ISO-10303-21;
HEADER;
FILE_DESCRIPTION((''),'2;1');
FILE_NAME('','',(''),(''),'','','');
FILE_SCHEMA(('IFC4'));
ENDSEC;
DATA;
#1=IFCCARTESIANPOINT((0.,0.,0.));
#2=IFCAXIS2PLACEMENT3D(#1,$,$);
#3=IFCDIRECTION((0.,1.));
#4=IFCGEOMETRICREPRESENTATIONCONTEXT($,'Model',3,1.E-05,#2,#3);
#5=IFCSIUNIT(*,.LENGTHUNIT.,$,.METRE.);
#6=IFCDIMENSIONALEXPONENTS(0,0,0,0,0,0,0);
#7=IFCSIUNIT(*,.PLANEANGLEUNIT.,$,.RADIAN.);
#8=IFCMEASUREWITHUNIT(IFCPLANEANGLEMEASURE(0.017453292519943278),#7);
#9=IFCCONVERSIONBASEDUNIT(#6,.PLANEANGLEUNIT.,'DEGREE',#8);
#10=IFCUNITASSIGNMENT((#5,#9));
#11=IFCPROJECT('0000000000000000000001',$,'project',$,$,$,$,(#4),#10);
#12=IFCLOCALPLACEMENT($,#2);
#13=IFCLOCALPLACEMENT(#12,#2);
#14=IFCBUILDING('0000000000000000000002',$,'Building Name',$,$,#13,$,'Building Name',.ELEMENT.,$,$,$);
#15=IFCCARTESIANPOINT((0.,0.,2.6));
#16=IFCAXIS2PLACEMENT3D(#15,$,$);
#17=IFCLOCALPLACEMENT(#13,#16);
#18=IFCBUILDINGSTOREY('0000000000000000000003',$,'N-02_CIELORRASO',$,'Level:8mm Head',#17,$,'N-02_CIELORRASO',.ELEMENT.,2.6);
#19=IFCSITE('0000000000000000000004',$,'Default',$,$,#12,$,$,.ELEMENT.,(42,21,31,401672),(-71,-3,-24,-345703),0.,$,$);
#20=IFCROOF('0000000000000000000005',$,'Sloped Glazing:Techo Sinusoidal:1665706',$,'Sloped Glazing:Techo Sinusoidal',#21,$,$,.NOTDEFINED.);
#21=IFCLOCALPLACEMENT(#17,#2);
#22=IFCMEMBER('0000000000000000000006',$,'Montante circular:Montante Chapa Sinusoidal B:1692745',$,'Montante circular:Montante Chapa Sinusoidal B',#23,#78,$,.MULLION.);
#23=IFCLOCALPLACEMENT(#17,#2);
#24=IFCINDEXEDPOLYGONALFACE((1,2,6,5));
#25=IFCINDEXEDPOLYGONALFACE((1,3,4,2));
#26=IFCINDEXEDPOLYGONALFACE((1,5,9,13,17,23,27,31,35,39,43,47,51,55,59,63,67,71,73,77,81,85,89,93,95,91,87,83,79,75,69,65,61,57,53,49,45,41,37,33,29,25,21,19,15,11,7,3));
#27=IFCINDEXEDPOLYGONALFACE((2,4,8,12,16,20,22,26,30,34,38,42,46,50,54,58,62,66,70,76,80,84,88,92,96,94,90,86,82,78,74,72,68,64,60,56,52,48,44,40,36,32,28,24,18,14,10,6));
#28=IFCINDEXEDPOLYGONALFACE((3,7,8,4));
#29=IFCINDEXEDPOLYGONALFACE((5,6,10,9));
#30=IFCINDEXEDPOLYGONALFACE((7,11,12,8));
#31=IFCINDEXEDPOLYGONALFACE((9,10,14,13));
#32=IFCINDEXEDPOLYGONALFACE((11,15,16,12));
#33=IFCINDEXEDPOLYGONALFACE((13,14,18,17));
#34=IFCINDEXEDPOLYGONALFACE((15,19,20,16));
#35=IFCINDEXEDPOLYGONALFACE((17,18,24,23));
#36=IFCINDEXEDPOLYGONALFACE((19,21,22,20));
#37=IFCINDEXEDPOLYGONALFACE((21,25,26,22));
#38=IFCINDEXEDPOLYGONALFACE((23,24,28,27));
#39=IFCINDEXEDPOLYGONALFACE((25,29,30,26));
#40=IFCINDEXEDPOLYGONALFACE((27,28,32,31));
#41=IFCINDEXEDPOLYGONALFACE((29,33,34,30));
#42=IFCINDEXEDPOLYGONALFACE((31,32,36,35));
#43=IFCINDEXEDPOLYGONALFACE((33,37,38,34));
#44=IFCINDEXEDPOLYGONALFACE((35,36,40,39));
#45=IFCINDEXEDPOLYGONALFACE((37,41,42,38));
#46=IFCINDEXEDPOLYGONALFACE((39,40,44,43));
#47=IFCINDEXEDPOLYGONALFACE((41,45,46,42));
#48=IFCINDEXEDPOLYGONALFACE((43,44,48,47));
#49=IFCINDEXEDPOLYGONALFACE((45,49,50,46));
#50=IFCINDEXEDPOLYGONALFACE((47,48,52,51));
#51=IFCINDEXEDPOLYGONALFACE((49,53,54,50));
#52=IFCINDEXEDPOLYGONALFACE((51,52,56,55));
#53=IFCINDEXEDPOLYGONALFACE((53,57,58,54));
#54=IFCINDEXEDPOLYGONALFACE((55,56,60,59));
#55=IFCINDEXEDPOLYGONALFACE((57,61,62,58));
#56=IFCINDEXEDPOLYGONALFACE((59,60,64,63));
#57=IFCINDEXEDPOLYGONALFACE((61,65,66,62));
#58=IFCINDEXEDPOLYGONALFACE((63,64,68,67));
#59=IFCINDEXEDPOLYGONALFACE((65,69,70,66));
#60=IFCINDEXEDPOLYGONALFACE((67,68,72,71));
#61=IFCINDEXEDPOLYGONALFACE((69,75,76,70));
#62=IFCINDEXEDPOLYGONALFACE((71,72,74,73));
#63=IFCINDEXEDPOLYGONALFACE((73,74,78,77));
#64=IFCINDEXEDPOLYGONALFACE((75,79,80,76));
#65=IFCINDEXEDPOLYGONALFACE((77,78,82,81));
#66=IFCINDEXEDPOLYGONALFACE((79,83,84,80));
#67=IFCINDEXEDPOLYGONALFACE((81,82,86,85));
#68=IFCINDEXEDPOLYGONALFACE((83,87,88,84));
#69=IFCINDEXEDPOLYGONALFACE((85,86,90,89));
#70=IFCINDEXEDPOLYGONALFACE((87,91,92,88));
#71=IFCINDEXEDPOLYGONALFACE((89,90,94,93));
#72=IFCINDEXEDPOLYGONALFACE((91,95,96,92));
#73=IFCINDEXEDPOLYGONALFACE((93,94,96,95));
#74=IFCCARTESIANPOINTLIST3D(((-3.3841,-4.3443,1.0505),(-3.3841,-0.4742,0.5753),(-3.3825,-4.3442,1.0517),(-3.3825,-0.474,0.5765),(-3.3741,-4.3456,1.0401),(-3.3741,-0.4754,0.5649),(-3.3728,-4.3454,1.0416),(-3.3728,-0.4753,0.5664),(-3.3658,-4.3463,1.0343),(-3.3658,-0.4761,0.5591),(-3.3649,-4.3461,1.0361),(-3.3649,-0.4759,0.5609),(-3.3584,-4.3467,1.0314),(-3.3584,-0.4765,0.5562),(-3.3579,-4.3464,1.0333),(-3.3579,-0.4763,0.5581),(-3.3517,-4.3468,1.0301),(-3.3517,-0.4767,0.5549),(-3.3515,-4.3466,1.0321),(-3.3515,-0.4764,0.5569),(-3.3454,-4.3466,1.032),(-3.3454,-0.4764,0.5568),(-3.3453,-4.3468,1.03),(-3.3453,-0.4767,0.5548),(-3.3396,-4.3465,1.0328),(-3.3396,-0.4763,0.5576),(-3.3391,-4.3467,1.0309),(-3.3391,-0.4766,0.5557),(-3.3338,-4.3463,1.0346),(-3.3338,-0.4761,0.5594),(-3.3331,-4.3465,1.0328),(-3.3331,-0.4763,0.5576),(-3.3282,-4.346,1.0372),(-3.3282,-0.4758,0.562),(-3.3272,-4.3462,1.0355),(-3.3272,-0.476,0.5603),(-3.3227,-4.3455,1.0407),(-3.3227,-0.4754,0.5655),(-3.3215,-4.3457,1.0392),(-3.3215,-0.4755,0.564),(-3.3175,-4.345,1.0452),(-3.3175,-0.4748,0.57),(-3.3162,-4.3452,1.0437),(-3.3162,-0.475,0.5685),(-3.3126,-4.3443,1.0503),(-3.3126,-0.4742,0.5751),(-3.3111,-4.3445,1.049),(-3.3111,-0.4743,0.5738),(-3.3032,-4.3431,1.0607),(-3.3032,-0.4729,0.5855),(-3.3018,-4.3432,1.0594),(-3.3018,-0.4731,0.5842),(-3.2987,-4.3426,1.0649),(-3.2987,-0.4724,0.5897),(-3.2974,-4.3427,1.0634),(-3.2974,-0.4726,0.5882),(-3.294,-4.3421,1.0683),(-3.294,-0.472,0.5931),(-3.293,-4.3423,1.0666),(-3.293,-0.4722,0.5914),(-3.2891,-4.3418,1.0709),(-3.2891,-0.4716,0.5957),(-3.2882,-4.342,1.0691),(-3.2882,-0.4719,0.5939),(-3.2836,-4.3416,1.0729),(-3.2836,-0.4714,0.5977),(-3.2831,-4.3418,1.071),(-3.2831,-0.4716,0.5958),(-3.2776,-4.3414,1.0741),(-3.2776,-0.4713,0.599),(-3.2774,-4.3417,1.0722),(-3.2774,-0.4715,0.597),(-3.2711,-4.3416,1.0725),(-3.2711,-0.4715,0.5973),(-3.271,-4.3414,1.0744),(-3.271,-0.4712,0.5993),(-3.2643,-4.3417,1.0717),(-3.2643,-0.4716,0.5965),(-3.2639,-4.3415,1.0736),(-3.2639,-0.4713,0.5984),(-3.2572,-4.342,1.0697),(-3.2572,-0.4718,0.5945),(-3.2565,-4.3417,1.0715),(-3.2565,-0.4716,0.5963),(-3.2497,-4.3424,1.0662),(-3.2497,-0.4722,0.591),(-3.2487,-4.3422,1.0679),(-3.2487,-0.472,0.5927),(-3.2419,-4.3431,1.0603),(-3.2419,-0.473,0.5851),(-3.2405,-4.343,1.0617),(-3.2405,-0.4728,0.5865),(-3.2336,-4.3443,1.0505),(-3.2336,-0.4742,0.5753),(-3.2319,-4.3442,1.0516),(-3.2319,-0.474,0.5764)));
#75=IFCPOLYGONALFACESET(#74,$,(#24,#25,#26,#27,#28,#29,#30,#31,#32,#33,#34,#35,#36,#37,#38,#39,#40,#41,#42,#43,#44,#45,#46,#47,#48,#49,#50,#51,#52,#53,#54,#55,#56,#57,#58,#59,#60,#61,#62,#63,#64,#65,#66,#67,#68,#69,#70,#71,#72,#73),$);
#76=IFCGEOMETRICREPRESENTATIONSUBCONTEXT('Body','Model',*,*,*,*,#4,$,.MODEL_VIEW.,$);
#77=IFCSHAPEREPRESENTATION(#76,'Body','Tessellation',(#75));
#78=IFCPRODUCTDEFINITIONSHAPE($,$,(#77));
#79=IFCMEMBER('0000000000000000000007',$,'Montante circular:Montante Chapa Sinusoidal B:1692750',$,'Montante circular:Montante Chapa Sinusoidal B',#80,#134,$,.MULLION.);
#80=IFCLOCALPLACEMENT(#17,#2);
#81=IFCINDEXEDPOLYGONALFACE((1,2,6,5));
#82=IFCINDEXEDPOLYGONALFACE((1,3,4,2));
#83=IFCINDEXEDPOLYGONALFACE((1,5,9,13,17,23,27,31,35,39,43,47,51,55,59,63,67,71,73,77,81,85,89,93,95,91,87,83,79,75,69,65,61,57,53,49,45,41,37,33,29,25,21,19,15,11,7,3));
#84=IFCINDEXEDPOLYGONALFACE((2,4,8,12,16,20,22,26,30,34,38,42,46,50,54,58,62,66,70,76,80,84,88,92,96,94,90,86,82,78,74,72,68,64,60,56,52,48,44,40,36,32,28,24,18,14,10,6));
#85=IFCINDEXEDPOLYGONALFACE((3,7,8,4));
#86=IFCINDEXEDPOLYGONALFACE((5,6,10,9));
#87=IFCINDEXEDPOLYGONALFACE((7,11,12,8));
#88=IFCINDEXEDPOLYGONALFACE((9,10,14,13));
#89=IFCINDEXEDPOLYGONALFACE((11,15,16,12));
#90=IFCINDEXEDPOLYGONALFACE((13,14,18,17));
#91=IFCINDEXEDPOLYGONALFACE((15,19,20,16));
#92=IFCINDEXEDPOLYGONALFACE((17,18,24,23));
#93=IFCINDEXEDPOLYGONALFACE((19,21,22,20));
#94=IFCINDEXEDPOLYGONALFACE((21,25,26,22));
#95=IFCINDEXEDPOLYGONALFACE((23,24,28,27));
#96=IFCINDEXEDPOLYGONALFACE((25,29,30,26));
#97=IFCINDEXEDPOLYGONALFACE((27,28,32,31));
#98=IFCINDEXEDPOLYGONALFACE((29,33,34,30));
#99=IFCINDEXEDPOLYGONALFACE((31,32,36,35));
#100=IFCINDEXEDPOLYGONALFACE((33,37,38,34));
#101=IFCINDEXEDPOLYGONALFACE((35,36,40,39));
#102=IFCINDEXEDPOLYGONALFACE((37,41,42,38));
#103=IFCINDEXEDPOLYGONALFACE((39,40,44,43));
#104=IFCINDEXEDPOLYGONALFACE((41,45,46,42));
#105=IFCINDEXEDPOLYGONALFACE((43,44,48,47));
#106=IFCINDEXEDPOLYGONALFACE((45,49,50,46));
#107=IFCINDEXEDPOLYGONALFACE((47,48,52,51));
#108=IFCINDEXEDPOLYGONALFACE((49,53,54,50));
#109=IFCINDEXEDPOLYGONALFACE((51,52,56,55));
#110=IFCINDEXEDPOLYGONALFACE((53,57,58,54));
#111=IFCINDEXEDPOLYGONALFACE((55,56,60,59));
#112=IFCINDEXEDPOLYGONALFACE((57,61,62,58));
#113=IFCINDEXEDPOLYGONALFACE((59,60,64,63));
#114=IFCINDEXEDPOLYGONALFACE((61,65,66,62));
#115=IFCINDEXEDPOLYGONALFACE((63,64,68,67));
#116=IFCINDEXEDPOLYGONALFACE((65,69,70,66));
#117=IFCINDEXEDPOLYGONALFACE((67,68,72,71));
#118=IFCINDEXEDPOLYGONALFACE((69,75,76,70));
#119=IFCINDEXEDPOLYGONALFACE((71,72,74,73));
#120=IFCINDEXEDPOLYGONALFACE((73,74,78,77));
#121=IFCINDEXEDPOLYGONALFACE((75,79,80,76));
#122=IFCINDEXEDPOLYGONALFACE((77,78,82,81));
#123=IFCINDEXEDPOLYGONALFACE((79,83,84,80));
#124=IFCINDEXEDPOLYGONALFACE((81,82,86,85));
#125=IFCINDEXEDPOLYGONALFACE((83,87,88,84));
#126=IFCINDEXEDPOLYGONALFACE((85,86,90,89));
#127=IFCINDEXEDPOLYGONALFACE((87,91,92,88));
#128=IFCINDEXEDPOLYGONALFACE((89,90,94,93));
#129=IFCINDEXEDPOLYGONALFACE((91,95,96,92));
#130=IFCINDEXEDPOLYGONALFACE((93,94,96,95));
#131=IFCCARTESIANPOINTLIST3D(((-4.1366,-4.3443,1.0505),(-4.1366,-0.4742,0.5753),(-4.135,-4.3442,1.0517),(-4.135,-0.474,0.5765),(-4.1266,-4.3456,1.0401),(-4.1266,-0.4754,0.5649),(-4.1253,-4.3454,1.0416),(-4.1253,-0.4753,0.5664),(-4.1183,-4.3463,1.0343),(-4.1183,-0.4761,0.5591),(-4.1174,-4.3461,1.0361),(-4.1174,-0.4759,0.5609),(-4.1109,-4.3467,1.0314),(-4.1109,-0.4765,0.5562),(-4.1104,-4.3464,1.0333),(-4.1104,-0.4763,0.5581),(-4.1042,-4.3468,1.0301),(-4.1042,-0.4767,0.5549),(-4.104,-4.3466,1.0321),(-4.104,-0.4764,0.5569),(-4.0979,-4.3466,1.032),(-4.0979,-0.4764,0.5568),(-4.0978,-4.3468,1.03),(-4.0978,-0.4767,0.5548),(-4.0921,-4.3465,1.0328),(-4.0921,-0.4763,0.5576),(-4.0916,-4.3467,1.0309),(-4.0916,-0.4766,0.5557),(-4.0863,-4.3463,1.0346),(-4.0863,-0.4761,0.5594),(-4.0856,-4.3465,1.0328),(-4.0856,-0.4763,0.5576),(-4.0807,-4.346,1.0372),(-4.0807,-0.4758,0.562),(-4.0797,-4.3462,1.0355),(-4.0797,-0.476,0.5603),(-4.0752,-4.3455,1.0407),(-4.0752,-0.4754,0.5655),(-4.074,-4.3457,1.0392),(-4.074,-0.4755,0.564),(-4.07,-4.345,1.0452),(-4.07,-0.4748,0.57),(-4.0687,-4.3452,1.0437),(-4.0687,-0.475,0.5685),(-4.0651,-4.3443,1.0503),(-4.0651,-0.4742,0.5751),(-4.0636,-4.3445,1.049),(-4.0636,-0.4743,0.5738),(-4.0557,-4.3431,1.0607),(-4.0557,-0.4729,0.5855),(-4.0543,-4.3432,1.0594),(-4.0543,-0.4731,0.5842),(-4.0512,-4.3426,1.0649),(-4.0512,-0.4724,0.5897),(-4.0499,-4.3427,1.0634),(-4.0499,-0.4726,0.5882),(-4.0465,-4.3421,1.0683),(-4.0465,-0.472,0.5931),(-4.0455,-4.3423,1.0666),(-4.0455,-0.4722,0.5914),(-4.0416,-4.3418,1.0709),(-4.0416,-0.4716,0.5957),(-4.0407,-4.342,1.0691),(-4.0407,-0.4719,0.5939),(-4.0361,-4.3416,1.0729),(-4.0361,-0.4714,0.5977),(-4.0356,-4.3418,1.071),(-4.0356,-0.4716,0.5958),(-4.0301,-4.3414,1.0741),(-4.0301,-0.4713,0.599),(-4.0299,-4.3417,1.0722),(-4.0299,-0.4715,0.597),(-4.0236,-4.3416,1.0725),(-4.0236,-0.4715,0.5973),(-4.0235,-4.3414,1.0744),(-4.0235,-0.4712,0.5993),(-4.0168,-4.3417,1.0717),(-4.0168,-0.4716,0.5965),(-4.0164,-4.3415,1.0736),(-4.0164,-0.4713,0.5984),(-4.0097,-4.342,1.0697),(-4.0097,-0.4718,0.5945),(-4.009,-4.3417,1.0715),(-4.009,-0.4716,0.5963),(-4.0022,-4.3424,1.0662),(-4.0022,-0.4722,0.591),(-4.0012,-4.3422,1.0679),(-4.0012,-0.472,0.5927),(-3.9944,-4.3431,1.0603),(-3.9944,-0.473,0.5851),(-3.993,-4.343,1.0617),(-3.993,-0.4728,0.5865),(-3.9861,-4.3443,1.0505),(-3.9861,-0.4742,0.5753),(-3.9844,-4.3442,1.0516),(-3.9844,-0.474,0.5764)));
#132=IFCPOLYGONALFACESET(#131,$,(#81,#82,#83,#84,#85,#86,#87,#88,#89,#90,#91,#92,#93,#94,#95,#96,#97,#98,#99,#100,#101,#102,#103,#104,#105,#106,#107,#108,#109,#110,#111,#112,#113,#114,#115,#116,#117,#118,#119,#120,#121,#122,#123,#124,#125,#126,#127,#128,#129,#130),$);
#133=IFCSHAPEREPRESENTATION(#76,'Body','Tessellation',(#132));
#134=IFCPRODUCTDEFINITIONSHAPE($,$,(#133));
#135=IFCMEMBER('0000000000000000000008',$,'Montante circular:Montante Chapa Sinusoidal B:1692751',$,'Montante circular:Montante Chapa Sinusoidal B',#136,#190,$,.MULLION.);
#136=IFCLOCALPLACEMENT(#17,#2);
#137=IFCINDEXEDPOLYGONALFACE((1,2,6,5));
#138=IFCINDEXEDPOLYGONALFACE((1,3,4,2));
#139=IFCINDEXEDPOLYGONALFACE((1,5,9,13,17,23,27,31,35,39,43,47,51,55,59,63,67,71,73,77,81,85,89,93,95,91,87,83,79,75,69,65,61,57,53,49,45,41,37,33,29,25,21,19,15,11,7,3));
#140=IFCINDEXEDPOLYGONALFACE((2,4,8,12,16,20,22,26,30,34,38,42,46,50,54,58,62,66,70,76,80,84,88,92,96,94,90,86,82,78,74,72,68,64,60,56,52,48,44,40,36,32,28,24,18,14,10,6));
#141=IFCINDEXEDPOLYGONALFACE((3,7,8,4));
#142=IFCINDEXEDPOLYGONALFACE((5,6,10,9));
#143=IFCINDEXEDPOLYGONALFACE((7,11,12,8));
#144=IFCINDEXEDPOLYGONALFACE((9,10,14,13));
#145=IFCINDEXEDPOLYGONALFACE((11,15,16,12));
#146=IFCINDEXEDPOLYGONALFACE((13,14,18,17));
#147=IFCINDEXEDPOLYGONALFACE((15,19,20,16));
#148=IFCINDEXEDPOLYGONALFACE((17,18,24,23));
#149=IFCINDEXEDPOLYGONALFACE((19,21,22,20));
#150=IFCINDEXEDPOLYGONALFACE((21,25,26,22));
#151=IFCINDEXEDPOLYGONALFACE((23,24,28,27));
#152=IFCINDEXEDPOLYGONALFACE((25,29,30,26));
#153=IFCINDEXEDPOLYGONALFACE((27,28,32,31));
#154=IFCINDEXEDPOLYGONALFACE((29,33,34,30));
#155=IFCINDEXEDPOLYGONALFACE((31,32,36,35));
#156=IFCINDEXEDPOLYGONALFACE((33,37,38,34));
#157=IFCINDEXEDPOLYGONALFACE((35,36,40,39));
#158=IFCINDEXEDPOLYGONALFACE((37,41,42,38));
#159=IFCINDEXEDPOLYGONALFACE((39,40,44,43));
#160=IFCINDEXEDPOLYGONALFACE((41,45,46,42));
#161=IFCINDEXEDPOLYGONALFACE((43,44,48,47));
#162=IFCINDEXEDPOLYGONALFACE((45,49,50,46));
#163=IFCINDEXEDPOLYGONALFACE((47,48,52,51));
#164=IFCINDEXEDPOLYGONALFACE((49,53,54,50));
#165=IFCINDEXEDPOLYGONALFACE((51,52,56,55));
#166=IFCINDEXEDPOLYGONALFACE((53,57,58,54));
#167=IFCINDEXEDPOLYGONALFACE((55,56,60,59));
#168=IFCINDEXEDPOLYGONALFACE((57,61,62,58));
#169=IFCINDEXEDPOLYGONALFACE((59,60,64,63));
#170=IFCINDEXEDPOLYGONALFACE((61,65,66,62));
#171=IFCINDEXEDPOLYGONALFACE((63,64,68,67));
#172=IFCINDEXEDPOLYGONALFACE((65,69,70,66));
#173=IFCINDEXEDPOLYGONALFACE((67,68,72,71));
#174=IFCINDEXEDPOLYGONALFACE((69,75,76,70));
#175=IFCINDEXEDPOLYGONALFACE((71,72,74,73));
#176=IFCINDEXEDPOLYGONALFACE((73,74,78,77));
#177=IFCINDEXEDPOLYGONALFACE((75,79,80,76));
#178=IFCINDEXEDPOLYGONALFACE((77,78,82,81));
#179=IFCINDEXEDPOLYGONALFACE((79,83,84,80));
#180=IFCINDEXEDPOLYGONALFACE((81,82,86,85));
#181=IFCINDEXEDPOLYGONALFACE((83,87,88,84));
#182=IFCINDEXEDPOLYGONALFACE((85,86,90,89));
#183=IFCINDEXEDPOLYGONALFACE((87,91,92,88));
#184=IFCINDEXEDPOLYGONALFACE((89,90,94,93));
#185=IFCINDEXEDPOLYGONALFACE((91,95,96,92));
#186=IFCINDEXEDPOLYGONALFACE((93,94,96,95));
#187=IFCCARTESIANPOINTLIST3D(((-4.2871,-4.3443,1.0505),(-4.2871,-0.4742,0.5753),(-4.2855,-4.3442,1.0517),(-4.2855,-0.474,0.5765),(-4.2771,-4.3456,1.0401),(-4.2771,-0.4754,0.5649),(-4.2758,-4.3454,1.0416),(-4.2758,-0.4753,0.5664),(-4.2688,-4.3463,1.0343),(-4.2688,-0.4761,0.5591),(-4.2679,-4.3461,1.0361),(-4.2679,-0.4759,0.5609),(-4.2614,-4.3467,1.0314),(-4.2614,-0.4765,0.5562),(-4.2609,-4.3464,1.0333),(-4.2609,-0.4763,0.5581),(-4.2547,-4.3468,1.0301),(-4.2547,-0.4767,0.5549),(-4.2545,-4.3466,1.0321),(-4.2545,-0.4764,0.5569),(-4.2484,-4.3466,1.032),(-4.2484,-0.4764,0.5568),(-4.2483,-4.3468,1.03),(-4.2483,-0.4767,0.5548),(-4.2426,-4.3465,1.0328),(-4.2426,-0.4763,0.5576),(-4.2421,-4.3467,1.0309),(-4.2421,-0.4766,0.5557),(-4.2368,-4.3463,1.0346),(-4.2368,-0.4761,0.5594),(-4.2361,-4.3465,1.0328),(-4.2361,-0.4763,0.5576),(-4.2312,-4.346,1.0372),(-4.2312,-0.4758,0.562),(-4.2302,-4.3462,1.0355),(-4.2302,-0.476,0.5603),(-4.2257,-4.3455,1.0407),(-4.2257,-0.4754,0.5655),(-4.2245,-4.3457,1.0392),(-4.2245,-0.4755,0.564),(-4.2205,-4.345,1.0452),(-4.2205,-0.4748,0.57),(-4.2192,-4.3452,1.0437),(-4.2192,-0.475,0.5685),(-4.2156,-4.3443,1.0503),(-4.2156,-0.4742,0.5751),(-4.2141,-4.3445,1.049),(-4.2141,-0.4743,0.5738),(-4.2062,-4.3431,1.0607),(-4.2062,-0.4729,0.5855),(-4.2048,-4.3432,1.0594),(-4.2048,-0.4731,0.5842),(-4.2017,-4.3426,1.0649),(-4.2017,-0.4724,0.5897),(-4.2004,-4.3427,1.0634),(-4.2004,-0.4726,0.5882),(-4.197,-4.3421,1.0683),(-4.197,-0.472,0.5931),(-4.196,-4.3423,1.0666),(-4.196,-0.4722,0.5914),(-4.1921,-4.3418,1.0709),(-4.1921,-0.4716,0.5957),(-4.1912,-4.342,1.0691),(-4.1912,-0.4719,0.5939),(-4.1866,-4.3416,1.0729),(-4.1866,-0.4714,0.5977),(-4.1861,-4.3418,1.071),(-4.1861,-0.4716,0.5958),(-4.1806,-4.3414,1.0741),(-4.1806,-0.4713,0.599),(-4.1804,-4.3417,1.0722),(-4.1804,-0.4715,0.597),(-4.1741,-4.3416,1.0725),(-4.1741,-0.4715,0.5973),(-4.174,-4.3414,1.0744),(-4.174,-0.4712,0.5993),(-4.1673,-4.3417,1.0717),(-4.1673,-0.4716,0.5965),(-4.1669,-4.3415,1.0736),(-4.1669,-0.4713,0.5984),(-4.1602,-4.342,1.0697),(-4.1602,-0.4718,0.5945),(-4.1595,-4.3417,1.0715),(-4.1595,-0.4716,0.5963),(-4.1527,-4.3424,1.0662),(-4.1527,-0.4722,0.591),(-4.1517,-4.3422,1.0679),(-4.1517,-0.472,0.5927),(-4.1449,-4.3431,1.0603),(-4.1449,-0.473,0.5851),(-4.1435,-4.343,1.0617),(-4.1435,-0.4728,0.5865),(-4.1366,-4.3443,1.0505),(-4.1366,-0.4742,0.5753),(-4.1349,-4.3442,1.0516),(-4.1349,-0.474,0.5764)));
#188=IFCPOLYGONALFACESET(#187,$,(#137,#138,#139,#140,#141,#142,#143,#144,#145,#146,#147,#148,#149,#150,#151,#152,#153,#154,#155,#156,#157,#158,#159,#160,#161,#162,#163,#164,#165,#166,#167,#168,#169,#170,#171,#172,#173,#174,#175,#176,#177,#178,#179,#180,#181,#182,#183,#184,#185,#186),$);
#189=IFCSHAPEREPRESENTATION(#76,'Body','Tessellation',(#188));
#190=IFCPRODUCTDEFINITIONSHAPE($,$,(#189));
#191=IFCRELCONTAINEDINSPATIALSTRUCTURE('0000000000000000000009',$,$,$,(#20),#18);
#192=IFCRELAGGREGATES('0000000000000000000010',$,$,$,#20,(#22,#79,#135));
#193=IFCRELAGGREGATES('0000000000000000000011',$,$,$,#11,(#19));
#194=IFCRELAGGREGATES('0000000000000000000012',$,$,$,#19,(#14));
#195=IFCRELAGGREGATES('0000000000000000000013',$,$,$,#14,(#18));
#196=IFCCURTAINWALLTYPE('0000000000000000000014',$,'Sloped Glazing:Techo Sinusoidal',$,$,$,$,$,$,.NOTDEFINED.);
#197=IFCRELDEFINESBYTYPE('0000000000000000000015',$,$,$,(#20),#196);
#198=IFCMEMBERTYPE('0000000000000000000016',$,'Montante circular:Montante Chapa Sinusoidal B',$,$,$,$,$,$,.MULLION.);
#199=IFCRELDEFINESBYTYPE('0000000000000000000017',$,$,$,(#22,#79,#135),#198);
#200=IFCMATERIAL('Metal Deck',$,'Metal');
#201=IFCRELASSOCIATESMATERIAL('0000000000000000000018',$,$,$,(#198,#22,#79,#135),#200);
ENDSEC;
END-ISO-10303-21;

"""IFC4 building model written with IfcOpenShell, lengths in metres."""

from ifc_helpers import new_model, entity, si_unit, converted_unit, direction, frame, origin, place, context, subcontext, project, spatial, indexed_curve, outline, extrude, source, transform, mapped, material, type_object, type_shapes, element, aggregate, save


model = new_model("IFC4")

# Units and contexts
model_context = context("Model", 3, precision=1e-05, world=origin(), true_north=direction((0.0, 1.0)))
body_context = subcontext(model_context, "Body", "Model", "MODEL_VIEW")
ifc_project = project(units=[si_unit("LENGTHUNIT", "METRE"), converted_unit("PLANEANGLEUNIT", "DEGREE", entity("IfcPlaneAngleMeasure", 0.017453292519943278), si_unit("PLANEANGLEUNIT", "RADIAN"), dimensions=[0, 0, 0, 0, 0, 0, 0])], contexts=[model_context])

# Site, building, storey
site_placement = place(None, origin())
site = spatial("IfcSite", under=ifc_project, at=site_placement, Name="Default", CompositionType="ELEMENT", RefLatitude=(42, 21, 31, 401672), RefLongitude=(-71, -3, -24, -345703), RefElevation=0.0)
building_placement = place(site_placement, origin())
building = spatial("IfcBuilding", under=site, at=building_placement, Name="Building Name", LongName="Building Name", CompositionType="ELEMENT")
storey_placement = place(building_placement, frame((0.0, 0.0, 2.6)))
storey = spatial("IfcBuildingStorey", under=building, at=storey_placement, Name="N-02_CIELORRASO", ObjectType="Level:8mm Head", LongName="N-02_CIELORRASO", CompositionType="ELEMENT", Elevation=2.6)

# Roof, members
curtain_wall_type = type_object("IfcCurtainWallType", Name="Sloped Glazing:Techo Sinusoidal", PredefinedType="NOTDEFINED")
ifc_material = material(Name="Metal Deck", Category="Metal")
roof_1_placement = place(storey_placement, frame((0.0, 0.0, -2.6)))
roof_1 = element("IfcRoof", 1, at=roof_1_placement, inside=storey, type_object=curtain_wall_type, Name="Sloped Glazing:Techo Sinusoidal:1665706", ObjectType="Sloped Glazing:Techo Sinusoidal", PredefinedType="NOTDEFINED")
member_type_1 = type_object("IfcMemberType", Name="Montante circular:Montante Chapa Sinusoidal B", PredefinedType="MULLION", material=ifc_material)
shared_shape_1 = source(origin(), body_context, "Body", "SweptSolid", [
    extrude(outline(indexed_curve([(0.0595, -0.0443), (0.0615, -0.0443), (0.0603, -0.031), (0.0572, -0.0213), (0.053, -0.0138), (0.0481, -0.0078), (0.0427, -0.003), (0.0372, 0.0005), (0.0315, 0.0029), (0.0259, 0.0044), (0.0203, 0.0051), (0.0146, 0.005), (0.0084, 0.0041), (-0.0053, 0.0009), (-0.0123, -0.0005), (-0.0191, -0.0012), (-0.0256, -0.001), (-0.0317, 0.0001), (-0.0375, 0.0019), (-0.0428, 0.0046), (-0.0477, 0.0081), (-0.0522, 0.0128), (-0.0563, 0.0191), (-0.0597, 0.0282), (-0.0617, 0.0421), (-0.0637, 0.042), (-0.0616, 0.0277), (-0.0581, 0.0182), (-0.0537, 0.0116), (-0.049, 0.0066), (-0.0438, 0.0028), (-0.0382, 0.0001), (-0.0322, -0.0019), (-0.0258, -0.003), (-0.019, -0.0032), (-0.012, -0.0025), (-0.0048, -0.0011), (0.0088, 0.0021), (0.0147, 0.003), (0.0202, 0.0031), (0.0255, 0.0024), (0.0309, 0.001), (0.0362, -0.0013), (0.0415, -0.0046), (0.0466, -0.0092), (0.0513, -0.0149), (0.0554, -0.0221), (0.0584, -0.0314), (0.0595, -0.0443)], self_intersect=False)), frame((-0.007, 0.0228, -3.8992), z_axis=(0.0, 0.0, 1.0), x_axis=(-0.819152, -0.573576, 0.0)), (0.0, 0.0, 1.0), 3.8992),
])
type_shapes(member_type_1, [shared_shape_1])
member_1_placement = place(roof_1_placement, frame((-3.3148, -4.3413, 3.6752), z_axis=(0.0, -0.992546, 0.121869), x_axis=(-1.0, 0.0, 0.0)))
member_1 = element("IfcMember", 2, at=member_1_placement, type_object=member_type_1, material=ifc_material, Name="Montante circular:Montante Chapa Sinusoidal B:1692745", ObjectType="Montante circular:Montante Chapa Sinusoidal B", PredefinedType="MULLION", context=body_context, shape_type="MappedRepresentation", body=[
    mapped(shared_shape_1, transform((0.0, 0.0, 0.0), scale=1.0)),
])
member_2_placement = place(roof_1_placement, frame((-4.0673, -4.3413, 3.6752), z_axis=(0.0, -0.992546, 0.121869), x_axis=(-1.0, 0.0, 0.0)))
member_2 = element("IfcMember", 3, at=member_2_placement, type_object=member_type_1, material=ifc_material, Name="Montante circular:Montante Chapa Sinusoidal B:1692750", ObjectType="Montante circular:Montante Chapa Sinusoidal B", PredefinedType="MULLION", context=body_context, shape_type="MappedRepresentation", body=[
    mapped(shared_shape_1, transform((0.0, 0.0, 0.0), scale=1.0)),
])
member_3_placement = place(roof_1_placement, frame((-4.2178, -4.3413, 3.6752), z_axis=(0.0, -0.992546, 0.121869), x_axis=(-1.0, 0.0, 0.0)))
member_3 = element("IfcMember", 4, at=member_3_placement, type_object=member_type_1, material=ifc_material, Name="Montante circular:Montante Chapa Sinusoidal B:1692751", ObjectType="Montante circular:Montante Chapa Sinusoidal B", PredefinedType="MULLION", context=body_context, shape_type="MappedRepresentation", body=[
    mapped(shared_shape_1, transform((0.0, 0.0, 0.0), scale=1.0)),
])
aggregate(roof_1, [member_1, member_2, member_3])

save(model, "model.ifc")
